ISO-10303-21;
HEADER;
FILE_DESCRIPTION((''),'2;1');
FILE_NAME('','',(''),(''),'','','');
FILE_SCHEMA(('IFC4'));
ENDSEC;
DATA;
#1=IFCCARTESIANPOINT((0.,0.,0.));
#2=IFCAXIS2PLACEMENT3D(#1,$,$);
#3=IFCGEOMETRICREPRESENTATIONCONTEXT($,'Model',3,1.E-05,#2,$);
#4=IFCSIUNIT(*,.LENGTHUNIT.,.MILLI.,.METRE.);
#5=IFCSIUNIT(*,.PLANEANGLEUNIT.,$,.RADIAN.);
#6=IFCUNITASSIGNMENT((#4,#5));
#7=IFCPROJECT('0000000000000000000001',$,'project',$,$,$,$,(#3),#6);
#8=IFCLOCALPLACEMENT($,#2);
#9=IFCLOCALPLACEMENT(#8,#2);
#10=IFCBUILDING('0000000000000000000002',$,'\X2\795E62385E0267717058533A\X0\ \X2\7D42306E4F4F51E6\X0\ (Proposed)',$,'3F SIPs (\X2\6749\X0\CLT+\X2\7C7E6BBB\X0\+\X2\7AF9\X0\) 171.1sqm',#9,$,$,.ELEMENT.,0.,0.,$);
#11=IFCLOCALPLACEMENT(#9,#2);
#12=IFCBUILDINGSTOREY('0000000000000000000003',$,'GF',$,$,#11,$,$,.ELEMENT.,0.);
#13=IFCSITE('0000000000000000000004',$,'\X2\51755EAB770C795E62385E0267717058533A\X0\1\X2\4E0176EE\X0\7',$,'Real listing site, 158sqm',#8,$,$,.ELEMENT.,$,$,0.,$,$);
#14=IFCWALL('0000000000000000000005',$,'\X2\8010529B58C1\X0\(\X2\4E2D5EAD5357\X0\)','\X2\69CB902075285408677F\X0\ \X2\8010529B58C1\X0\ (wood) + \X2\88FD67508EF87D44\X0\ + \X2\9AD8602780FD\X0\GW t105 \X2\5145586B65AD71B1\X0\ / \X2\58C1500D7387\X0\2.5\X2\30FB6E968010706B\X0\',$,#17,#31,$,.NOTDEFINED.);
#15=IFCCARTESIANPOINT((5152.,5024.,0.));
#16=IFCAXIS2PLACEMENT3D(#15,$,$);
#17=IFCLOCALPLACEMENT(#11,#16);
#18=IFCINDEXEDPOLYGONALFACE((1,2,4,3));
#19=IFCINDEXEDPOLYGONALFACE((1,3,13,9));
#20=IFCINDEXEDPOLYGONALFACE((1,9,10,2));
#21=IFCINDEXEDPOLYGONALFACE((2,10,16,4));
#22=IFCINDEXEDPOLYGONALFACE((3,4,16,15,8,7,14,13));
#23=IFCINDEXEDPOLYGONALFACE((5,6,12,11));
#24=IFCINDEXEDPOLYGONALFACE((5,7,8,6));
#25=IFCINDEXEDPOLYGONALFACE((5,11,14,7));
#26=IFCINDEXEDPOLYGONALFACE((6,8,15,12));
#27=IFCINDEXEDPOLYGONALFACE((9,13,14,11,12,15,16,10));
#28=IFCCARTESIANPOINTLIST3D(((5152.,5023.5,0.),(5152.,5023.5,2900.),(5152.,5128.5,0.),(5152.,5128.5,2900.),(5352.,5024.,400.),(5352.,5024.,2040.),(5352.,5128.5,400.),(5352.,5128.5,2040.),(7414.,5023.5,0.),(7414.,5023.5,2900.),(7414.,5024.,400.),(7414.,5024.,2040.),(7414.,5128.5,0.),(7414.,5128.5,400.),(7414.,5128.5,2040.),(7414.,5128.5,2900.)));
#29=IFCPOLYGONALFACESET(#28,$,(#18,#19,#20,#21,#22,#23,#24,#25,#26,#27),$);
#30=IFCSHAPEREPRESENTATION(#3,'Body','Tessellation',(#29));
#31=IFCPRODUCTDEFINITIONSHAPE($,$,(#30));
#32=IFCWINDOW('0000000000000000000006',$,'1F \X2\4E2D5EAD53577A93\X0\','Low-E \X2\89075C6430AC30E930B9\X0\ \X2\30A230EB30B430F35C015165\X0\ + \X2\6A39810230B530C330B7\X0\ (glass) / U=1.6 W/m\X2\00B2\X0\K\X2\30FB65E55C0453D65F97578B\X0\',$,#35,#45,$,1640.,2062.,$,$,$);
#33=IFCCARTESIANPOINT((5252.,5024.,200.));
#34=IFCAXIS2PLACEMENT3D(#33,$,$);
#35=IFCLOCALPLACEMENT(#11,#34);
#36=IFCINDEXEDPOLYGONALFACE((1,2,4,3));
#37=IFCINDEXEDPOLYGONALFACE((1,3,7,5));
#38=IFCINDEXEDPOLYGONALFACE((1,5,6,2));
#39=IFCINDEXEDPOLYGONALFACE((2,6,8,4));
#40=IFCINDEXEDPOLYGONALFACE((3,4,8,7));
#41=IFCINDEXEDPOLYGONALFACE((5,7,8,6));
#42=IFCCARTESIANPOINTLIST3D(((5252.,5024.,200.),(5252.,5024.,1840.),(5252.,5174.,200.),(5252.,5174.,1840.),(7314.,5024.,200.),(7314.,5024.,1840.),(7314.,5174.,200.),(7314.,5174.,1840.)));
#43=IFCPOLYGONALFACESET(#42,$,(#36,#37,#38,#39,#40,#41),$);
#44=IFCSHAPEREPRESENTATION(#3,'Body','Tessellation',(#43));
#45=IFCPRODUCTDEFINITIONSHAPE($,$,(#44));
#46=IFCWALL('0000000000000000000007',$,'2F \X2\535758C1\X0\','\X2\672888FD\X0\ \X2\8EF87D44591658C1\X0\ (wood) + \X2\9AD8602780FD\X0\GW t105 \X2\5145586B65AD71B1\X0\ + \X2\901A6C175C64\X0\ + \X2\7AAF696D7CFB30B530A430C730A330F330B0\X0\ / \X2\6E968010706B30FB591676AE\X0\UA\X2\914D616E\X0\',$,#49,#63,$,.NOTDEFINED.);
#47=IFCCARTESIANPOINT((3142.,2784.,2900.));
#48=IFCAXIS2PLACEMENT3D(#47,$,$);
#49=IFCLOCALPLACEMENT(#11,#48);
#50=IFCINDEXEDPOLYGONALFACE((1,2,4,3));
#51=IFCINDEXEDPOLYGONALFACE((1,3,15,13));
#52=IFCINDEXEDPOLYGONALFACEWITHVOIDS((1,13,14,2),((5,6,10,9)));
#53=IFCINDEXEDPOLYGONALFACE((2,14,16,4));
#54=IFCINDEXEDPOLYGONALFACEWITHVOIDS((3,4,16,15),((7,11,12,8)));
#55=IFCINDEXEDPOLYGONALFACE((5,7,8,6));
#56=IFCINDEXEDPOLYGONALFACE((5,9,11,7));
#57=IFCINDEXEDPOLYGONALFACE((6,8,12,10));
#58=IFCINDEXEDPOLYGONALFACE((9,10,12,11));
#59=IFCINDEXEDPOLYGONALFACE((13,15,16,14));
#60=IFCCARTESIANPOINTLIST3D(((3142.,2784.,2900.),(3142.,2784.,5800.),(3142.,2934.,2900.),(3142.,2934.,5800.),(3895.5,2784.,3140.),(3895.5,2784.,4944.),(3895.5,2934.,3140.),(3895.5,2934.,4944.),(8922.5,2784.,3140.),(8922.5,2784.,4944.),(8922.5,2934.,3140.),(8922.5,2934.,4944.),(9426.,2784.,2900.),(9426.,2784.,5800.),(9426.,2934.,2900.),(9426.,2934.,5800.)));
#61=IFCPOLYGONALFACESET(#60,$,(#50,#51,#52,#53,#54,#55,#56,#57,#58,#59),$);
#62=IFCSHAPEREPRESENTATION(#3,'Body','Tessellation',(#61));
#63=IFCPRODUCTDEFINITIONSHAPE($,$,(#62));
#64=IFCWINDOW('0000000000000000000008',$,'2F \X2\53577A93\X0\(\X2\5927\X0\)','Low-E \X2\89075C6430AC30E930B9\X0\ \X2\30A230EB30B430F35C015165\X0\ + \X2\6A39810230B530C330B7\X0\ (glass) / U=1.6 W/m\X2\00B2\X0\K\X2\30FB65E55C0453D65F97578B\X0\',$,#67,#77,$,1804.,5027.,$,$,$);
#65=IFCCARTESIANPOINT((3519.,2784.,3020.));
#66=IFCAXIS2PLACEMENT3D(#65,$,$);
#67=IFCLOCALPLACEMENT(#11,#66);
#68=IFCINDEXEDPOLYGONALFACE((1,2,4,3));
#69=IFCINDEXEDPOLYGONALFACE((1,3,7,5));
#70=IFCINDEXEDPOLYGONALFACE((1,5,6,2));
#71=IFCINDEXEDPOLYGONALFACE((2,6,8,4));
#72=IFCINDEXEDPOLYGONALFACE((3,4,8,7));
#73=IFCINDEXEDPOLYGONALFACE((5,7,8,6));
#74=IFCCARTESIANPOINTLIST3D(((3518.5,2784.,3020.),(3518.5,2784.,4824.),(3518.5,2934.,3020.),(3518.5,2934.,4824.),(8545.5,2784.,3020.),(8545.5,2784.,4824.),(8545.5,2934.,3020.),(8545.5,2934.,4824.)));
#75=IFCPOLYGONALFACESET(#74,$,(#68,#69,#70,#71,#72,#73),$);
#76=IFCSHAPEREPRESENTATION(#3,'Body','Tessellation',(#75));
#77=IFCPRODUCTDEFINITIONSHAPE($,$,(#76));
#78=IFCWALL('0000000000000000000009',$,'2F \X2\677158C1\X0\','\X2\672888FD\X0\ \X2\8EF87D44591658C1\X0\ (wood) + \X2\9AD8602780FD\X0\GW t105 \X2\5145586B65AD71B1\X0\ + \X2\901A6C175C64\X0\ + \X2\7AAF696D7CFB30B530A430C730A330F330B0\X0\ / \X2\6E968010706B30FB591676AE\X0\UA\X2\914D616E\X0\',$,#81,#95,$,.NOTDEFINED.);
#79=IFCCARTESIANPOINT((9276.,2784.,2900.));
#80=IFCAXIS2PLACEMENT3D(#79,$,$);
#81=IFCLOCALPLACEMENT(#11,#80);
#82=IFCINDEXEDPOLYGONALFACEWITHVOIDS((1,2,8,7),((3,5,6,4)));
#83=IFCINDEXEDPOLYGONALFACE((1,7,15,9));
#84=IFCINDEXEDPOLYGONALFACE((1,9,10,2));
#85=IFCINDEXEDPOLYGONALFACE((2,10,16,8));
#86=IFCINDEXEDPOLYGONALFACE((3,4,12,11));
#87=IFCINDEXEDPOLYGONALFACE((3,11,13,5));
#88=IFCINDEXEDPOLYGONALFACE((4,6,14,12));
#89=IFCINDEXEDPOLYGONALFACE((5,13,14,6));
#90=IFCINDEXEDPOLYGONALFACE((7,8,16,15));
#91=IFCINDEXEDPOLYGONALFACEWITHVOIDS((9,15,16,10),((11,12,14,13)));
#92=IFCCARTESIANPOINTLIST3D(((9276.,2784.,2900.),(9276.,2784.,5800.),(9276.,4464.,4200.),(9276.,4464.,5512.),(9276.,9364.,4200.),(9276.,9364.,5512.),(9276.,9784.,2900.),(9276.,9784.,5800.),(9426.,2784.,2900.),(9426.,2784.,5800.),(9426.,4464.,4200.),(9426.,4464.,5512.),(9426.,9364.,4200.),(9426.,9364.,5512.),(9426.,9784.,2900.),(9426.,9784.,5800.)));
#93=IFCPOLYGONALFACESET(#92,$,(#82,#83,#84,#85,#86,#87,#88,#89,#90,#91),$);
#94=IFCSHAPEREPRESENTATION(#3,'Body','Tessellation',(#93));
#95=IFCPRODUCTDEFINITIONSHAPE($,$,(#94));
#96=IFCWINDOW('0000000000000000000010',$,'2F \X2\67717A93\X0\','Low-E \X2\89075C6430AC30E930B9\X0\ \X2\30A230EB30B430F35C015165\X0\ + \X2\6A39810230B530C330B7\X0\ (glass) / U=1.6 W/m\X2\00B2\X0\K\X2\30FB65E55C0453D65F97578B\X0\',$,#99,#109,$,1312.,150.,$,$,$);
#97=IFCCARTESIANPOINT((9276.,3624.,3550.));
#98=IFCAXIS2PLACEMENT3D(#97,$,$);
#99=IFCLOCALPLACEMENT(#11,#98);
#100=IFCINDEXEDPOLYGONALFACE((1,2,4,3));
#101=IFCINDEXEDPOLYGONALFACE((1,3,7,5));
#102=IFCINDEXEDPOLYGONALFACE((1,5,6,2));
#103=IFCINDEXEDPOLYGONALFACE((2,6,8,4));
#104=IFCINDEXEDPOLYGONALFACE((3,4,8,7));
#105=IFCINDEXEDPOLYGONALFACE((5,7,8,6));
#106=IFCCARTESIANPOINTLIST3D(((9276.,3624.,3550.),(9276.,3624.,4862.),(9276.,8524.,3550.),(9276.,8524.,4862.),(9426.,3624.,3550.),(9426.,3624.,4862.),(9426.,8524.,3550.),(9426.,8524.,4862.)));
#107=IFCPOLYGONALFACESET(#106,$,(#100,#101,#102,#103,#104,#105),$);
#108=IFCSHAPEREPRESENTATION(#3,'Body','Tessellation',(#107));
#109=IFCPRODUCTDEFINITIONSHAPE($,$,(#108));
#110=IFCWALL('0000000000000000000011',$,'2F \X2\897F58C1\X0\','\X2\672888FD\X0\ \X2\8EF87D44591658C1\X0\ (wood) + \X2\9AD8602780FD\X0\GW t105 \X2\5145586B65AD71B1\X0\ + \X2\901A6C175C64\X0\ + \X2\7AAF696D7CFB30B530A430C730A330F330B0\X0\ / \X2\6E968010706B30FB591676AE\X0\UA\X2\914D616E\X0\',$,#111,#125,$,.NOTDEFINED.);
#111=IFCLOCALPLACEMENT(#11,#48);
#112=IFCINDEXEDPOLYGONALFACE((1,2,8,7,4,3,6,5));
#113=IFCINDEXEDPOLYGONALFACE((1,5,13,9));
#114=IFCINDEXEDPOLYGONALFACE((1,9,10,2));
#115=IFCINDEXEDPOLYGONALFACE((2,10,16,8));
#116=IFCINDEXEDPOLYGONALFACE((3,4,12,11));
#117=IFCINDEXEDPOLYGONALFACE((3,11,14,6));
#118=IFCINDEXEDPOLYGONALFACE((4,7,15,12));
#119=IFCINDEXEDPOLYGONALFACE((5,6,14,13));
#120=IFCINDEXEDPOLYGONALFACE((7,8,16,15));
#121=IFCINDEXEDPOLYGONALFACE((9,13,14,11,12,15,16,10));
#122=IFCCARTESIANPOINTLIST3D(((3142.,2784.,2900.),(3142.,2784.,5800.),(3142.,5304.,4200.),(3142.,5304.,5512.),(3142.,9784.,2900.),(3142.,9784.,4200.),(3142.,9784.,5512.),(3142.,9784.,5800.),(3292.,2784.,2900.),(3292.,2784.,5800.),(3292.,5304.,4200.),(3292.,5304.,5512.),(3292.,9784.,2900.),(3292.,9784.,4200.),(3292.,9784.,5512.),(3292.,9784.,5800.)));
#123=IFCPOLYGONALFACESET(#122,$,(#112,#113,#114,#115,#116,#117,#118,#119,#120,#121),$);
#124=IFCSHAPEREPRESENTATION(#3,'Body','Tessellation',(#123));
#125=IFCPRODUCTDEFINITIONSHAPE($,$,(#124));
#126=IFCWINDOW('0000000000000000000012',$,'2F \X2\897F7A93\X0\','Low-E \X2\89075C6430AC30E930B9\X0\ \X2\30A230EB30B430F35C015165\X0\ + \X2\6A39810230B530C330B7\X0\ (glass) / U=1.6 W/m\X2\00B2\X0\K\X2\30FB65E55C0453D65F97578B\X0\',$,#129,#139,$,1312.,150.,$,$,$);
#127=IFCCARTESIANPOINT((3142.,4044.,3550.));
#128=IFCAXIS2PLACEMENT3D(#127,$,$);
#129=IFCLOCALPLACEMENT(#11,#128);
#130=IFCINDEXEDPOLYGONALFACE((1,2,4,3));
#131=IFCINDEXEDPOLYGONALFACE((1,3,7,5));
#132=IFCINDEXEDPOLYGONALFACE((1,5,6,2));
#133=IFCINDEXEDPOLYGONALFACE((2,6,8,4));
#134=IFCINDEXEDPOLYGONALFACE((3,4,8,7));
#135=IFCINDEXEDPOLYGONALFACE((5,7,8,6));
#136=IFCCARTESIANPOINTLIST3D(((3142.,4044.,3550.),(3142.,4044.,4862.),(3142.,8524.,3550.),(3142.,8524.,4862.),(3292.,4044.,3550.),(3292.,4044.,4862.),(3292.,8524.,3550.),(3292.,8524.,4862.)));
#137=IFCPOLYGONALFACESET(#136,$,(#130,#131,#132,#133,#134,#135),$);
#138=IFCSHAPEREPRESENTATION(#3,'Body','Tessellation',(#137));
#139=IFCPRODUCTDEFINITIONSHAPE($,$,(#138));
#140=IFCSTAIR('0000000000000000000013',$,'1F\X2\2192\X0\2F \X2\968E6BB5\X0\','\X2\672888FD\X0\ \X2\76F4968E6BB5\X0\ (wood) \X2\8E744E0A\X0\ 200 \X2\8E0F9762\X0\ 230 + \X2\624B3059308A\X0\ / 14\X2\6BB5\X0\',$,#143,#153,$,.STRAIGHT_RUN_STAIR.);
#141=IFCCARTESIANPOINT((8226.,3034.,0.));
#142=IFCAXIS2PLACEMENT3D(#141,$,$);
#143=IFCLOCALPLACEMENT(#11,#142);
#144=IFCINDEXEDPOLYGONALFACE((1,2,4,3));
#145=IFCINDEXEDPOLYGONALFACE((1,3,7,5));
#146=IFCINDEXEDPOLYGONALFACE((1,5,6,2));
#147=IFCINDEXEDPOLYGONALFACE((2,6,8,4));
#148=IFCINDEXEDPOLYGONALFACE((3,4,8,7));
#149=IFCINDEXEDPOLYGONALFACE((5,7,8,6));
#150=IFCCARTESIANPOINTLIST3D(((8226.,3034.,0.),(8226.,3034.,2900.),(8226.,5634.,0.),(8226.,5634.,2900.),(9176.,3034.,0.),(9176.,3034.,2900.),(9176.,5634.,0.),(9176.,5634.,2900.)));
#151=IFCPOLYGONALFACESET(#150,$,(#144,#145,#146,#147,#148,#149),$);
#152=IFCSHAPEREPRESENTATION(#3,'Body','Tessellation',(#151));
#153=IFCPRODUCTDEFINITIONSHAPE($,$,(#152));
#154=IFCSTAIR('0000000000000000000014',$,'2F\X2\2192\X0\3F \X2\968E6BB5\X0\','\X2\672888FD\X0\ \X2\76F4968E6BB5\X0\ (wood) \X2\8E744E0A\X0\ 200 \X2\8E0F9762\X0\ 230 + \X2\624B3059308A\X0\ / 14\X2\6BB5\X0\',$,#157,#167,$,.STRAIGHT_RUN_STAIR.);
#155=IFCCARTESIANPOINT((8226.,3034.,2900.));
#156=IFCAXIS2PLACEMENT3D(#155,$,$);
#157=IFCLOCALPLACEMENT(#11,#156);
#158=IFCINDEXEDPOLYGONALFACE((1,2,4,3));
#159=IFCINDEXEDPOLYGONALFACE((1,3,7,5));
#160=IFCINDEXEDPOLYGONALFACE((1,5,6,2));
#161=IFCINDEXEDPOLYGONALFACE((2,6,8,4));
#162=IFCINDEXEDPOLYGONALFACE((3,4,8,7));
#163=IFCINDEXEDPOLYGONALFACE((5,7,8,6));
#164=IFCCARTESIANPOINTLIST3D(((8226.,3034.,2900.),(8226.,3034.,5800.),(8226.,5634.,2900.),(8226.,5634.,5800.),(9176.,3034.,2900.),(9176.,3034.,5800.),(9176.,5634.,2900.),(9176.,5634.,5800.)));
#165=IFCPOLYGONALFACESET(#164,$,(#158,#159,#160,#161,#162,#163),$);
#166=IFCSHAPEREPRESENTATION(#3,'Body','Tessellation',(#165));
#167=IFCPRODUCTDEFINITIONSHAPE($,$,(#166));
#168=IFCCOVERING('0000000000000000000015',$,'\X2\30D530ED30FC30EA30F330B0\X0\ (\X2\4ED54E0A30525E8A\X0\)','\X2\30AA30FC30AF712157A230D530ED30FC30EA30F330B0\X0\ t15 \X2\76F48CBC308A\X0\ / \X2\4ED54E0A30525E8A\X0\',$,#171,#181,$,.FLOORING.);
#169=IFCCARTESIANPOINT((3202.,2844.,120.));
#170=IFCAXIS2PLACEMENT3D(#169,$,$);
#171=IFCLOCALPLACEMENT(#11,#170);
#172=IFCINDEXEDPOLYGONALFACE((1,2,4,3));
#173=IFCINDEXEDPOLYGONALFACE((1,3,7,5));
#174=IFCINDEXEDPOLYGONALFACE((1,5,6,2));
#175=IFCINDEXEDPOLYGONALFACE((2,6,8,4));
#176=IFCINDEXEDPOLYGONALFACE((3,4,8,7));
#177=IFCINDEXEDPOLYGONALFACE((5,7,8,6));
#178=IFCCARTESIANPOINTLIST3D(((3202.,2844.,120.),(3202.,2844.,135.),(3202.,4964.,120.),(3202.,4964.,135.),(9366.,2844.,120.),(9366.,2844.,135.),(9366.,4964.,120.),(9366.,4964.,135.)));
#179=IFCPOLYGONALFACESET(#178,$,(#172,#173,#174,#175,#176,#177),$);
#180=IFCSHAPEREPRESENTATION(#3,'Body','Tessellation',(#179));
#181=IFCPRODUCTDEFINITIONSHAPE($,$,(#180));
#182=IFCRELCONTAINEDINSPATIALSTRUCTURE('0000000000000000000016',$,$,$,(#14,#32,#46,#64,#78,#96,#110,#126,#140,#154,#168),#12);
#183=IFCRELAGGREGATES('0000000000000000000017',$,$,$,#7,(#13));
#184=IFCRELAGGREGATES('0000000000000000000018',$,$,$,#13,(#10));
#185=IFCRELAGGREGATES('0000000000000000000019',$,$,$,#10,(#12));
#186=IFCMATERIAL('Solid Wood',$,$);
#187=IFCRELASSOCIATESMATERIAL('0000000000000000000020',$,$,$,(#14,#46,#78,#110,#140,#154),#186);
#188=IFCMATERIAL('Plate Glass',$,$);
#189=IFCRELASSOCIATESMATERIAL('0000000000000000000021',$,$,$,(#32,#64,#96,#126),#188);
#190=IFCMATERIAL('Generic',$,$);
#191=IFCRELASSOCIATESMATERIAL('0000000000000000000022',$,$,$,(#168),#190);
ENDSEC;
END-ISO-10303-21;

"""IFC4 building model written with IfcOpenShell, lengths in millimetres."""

from ifc_helpers import new_model, si_unit, frame, frame_2d, origin, place, context, project, spatial, rectangle, extrude, material, element, fill, save


model = new_model("IFC4")

# Units and contexts
model_context = context("Model", 3, precision=1e-05, world=origin())
ifc_project = project(units=[si_unit("LENGTHUNIT", "METRE", prefix="MILLI"), si_unit("PLANEANGLEUNIT", "RADIAN")], contexts=[model_context])

# Site, building, storey
site_placement = place(None, origin())
site = spatial("IfcSite", under=ifc_project, at=site_placement, Name="兵庫県神戸市東灘区1丁目7", ObjectType="Real listing site, 158sqm", CompositionType="ELEMENT", RefElevation=0.0)
building_placement = place(site_placement, origin())
building = spatial("IfcBuilding", under=site, at=building_placement, Name="神戸市東灘区 終の住処 (Proposed)", ObjectType="3F SIPs (杉CLT+籾殻+竹) 171.1sqm", CompositionType="ELEMENT", ElevationOfRefHeight=0.0, ElevationOfTerrain=0.0)
storey_placement = place(building_placement, origin())
storey = spatial("IfcBuildingStorey", under=building, at=storey_placement, Name="GF", CompositionType="ELEMENT", Elevation=0.0)

# Shared definitions
ifc_material_1 = material(Name="Solid Wood")
ifc_material_2 = material(Name="Generic")

# Shared definitions
ifc_material_3 = material(Name="Plate Glass")

# Walls, openings, windows
wall_1_placement = place(storey_placement, frame((5152.0, 5024.0, 0.0)))
wall_1 = element("IfcWall", 1, at=wall_1_placement, inside=storey, material=ifc_material_1, Name="耐力壁(中庭南)", Description="構造用合板 耐力壁 (wood) + 製材軸組 + 高性能GW t105 充填断熱 / 壁倍率2.5・準耐火", PredefinedType="NOTDEFINED", context=model_context, shape_type="SweptSolid", body=[
    extrude(rectangle(XDim=2262.0, YDim=105.0, at=frame_2d((1131.0, 52.0))), frame((5152.0, 5024.0, 0.0)), (0.0, 0.0, 1.0), 2900.0),
])
opening_1_placement = place(storey_placement, frame((5252.0, 5024.0, 200.0)))
opening_1 = element("IfcOpeningElement", 2, at=opening_1_placement, cuts=wall_1, PredefinedType="NOTDEFINED", context=model_context, shape_type="SweptSolid", body=[
    extrude(rectangle(XDim=2062.0, YDim=150.0, at=frame_2d((1031.0, 75.0))), frame((5252.0, 5024.0, 200.0)), (0.0, 0.0, 1.0), 1640.0),
])
window_1_placement = place(storey_placement, frame((5252.0, 5024.0, 200.0)))
window_1 = element("IfcWindow", 3, at=window_1_placement, inside=storey, material=ifc_material_3, Name="1F 中庭南窓", Description="Low-E 複層ガラス アルゴン封入 + 樹脂サッシ (glass) / U=1.6 W/m²K・日射取得型", OverallHeight=1640.0, OverallWidth=2062.0, context=model_context, shape_type="SweptSolid", body=[
    extrude(rectangle(XDim=2062.0, YDim=150.0, at=frame_2d((1031.0, 75.0))), frame((5252.0, 5024.0, 200.0)), (0.0, 0.0, 1.0), 1640.0),
])
fill(opening_1, window_1)
wall_2_placement = place(storey_placement, frame((3142.0, 2784.0, 2900.0)))
wall_2 = element("IfcWall", 4, at=wall_2_placement, inside=storey, material=ifc_material_1, Name="2F 南壁", Description="木製 軸組外壁 (wood) + 高性能GW t105 充填断熱 + 通気層 + 窯業系サイディング / 準耐火・外皮UA配慮", PredefinedType="NOTDEFINED", context=model_context, shape_type="SweptSolid", body=[
    extrude(rectangle(XDim=6284.0, YDim=150.0, at=frame_2d((3142.0, 75.0))), frame((3142.0, 2784.0, 2900.0)), (0.0, 0.0, 1.0), 2900.0),
])
opening_2_placement = place(storey_placement, frame((3519.0, 2784.0, 3020.0)))
opening_2 = element("IfcOpeningElement", 5, at=opening_2_placement, cuts=wall_2, PredefinedType="NOTDEFINED", context=model_context, shape_type="SweptSolid", body=[
    extrude(rectangle(XDim=5027.0, YDim=150.0, at=frame_2d((2513.0, 75.0))), frame((3519.0, 2784.0, 3020.0)), (0.0, 0.0, 1.0), 1804.0),
])
window_2_placement = place(storey_placement, frame((3519.0, 2784.0, 3020.0)))
window_2 = element("IfcWindow", 6, at=window_2_placement, inside=storey, material=ifc_material_3, Name="2F 南窓(大)", Description="Low-E 複層ガラス アルゴン封入 + 樹脂サッシ (glass) / U=1.6 W/m²K・日射取得型", OverallHeight=1804.0, OverallWidth=5027.0, context=model_context, shape_type="SweptSolid", body=[
    extrude(rectangle(XDim=5027.0, YDim=150.0, at=frame_2d((2513.0, 75.0))), frame((3519.0, 2784.0, 3020.0)), (0.0, 0.0, 1.0), 1804.0),
])
fill(opening_2, window_2)
wall_3_placement = place(storey_placement, frame((9276.0, 2784.0, 2900.0)))
wall_3 = element("IfcWall", 7, at=wall_3_placement, inside=storey, material=ifc_material_1, Name="2F 東壁", Description="木製 軸組外壁 (wood) + 高性能GW t105 充填断熱 + 通気層 + 窯業系サイディング / 準耐火・外皮UA配慮", PredefinedType="NOTDEFINED", context=model_context, shape_type="SweptSolid", body=[
    extrude(rectangle(XDim=150.0, YDim=7000.0, at=frame_2d((75.0, 3500.0))), frame((9276.0, 2784.0, 2900.0)), (0.0, 0.0, 1.0), 2900.0),
])
opening_3_placement = place(storey_placement, frame((9276.0, 3624.0, 3550.0)))
opening_3 = element("IfcOpeningElement", 8, at=opening_3_placement, cuts=wall_3, PredefinedType="NOTDEFINED", context=model_context, shape_type="SweptSolid", body=[
    extrude(rectangle(XDim=150.0, YDim=4900.0, at=frame_2d((75.0, 2450.0))), frame((9276.0, 3624.0, 3550.0)), (0.0, 0.0, 1.0), 1312.0),
])
window_3_placement = place(storey_placement, frame((9276.0, 3624.0, 3550.0)))
window_3 = element("IfcWindow", 9, at=window_3_placement, inside=storey, material=ifc_material_3, Name="2F 東窓", Description="Low-E 複層ガラス アルゴン封入 + 樹脂サッシ (glass) / U=1.6 W/m²K・日射取得型", OverallHeight=1312.0, OverallWidth=150.0, context=model_context, shape_type="SweptSolid", body=[
    extrude(rectangle(XDim=150.0, YDim=4900.0, at=frame_2d((75.0, 2450.0))), frame((9276.0, 3624.0, 3550.0)), (0.0, 0.0, 1.0), 1312.0),
])
fill(opening_3, window_3)
wall_4_placement = place(storey_placement, frame((3142.0, 2784.0, 2900.0)))
wall_4 = element("IfcWall", 10, at=wall_4_placement, inside=storey, material=ifc_material_1, Name="2F 西壁", Description="木製 軸組外壁 (wood) + 高性能GW t105 充填断熱 + 通気層 + 窯業系サイディング / 準耐火・外皮UA配慮", PredefinedType="NOTDEFINED", context=model_context, shape_type="SweptSolid", body=[
    extrude(rectangle(XDim=150.0, YDim=7000.0, at=frame_2d((75.0, 3500.0))), frame((3142.0, 2784.0, 2900.0)), (0.0, 0.0, 1.0), 2900.0),
])
opening_4_placement = place(storey_placement, frame((3142.0, 4044.0, 3550.0)))
opening_4 = element("IfcOpeningElement", 11, at=opening_4_placement, cuts=wall_4, PredefinedType="NOTDEFINED", context=model_context, shape_type="SweptSolid", body=[
    extrude(rectangle(XDim=150.0, YDim=4480.0, at=frame_2d((75.0, 2240.0))), frame((3142.0, 4044.0, 3550.0)), (0.0, 0.0, 1.0), 1312.0),
])
window_4_placement = place(storey_placement, frame((3142.0, 4044.0, 3550.0)))
window_4 = element("IfcWindow", 12, at=window_4_placement, inside=storey, material=ifc_material_3, Name="2F 西窓", Description="Low-E 複層ガラス アルゴン封入 + 樹脂サッシ (glass) / U=1.6 W/m²K・日射取得型", OverallHeight=1312.0, OverallWidth=150.0, context=model_context, shape_type="SweptSolid", body=[
    extrude(rectangle(XDim=150.0, YDim=4480.0, at=frame_2d((75.0, 2240.0))), frame((3142.0, 4044.0, 3550.0)), (0.0, 0.0, 1.0), 1312.0),
])
fill(opening_4, window_4)

# Stairs
stair_1_placement = place(storey_placement, frame((8226.0, 3034.0, 0.0)))
element("IfcStair", 13, at=stair_1_placement, inside=storey, material=ifc_material_1, Name="1F→2F 階段", Description="木製 直階段 (wood) 蹴上 200 踏面 230 + 手すり / 14段", PredefinedType="STRAIGHT_RUN_STAIR", context=model_context, shape_type="SweptSolid", body=[
    extrude(rectangle(XDim=950.0, YDim=2600.0, at=frame_2d((475.0, 1300.0))), frame((8226.0, 3034.0, 0.0)), (0.0, 0.0, 1.0), 2900.0),
])
stair_2_placement = place(storey_placement, frame((8226.0, 3034.0, 2900.0)))
element("IfcStair", 14, at=stair_2_placement, inside=storey, material=ifc_material_1, Name="2F→3F 階段", Description="木製 直階段 (wood) 蹴上 200 踏面 230 + 手すり / 14段", PredefinedType="STRAIGHT_RUN_STAIR", context=model_context, shape_type="SweptSolid", body=[
    extrude(rectangle(XDim=950.0, YDim=2600.0, at=frame_2d((475.0, 1300.0))), frame((8226.0, 3034.0, 2900.0)), (0.0, 0.0, 1.0), 2900.0),
])

# Covering
covering_placement = place(storey_placement, frame((3202.0, 2844.0, 120.0)))
element("IfcCovering", 15, at=covering_placement, inside=storey, material=ifc_material_2, Name="フローリング (仕上げ床)", Description="オーク無垢フローリング t15 直貼り / 仕上げ床", PredefinedType="FLOORING", context=model_context, shape_type="SweptSolid", body=[
    extrude(rectangle(XDim=6164.0, YDim=2120.0, at=frame_2d((3082.0, 1060.0))), frame((3202.0, 2844.0, 120.0)), (0.0, 0.0, 1.0), 15.0),
])

save(model, "model.ifc")
